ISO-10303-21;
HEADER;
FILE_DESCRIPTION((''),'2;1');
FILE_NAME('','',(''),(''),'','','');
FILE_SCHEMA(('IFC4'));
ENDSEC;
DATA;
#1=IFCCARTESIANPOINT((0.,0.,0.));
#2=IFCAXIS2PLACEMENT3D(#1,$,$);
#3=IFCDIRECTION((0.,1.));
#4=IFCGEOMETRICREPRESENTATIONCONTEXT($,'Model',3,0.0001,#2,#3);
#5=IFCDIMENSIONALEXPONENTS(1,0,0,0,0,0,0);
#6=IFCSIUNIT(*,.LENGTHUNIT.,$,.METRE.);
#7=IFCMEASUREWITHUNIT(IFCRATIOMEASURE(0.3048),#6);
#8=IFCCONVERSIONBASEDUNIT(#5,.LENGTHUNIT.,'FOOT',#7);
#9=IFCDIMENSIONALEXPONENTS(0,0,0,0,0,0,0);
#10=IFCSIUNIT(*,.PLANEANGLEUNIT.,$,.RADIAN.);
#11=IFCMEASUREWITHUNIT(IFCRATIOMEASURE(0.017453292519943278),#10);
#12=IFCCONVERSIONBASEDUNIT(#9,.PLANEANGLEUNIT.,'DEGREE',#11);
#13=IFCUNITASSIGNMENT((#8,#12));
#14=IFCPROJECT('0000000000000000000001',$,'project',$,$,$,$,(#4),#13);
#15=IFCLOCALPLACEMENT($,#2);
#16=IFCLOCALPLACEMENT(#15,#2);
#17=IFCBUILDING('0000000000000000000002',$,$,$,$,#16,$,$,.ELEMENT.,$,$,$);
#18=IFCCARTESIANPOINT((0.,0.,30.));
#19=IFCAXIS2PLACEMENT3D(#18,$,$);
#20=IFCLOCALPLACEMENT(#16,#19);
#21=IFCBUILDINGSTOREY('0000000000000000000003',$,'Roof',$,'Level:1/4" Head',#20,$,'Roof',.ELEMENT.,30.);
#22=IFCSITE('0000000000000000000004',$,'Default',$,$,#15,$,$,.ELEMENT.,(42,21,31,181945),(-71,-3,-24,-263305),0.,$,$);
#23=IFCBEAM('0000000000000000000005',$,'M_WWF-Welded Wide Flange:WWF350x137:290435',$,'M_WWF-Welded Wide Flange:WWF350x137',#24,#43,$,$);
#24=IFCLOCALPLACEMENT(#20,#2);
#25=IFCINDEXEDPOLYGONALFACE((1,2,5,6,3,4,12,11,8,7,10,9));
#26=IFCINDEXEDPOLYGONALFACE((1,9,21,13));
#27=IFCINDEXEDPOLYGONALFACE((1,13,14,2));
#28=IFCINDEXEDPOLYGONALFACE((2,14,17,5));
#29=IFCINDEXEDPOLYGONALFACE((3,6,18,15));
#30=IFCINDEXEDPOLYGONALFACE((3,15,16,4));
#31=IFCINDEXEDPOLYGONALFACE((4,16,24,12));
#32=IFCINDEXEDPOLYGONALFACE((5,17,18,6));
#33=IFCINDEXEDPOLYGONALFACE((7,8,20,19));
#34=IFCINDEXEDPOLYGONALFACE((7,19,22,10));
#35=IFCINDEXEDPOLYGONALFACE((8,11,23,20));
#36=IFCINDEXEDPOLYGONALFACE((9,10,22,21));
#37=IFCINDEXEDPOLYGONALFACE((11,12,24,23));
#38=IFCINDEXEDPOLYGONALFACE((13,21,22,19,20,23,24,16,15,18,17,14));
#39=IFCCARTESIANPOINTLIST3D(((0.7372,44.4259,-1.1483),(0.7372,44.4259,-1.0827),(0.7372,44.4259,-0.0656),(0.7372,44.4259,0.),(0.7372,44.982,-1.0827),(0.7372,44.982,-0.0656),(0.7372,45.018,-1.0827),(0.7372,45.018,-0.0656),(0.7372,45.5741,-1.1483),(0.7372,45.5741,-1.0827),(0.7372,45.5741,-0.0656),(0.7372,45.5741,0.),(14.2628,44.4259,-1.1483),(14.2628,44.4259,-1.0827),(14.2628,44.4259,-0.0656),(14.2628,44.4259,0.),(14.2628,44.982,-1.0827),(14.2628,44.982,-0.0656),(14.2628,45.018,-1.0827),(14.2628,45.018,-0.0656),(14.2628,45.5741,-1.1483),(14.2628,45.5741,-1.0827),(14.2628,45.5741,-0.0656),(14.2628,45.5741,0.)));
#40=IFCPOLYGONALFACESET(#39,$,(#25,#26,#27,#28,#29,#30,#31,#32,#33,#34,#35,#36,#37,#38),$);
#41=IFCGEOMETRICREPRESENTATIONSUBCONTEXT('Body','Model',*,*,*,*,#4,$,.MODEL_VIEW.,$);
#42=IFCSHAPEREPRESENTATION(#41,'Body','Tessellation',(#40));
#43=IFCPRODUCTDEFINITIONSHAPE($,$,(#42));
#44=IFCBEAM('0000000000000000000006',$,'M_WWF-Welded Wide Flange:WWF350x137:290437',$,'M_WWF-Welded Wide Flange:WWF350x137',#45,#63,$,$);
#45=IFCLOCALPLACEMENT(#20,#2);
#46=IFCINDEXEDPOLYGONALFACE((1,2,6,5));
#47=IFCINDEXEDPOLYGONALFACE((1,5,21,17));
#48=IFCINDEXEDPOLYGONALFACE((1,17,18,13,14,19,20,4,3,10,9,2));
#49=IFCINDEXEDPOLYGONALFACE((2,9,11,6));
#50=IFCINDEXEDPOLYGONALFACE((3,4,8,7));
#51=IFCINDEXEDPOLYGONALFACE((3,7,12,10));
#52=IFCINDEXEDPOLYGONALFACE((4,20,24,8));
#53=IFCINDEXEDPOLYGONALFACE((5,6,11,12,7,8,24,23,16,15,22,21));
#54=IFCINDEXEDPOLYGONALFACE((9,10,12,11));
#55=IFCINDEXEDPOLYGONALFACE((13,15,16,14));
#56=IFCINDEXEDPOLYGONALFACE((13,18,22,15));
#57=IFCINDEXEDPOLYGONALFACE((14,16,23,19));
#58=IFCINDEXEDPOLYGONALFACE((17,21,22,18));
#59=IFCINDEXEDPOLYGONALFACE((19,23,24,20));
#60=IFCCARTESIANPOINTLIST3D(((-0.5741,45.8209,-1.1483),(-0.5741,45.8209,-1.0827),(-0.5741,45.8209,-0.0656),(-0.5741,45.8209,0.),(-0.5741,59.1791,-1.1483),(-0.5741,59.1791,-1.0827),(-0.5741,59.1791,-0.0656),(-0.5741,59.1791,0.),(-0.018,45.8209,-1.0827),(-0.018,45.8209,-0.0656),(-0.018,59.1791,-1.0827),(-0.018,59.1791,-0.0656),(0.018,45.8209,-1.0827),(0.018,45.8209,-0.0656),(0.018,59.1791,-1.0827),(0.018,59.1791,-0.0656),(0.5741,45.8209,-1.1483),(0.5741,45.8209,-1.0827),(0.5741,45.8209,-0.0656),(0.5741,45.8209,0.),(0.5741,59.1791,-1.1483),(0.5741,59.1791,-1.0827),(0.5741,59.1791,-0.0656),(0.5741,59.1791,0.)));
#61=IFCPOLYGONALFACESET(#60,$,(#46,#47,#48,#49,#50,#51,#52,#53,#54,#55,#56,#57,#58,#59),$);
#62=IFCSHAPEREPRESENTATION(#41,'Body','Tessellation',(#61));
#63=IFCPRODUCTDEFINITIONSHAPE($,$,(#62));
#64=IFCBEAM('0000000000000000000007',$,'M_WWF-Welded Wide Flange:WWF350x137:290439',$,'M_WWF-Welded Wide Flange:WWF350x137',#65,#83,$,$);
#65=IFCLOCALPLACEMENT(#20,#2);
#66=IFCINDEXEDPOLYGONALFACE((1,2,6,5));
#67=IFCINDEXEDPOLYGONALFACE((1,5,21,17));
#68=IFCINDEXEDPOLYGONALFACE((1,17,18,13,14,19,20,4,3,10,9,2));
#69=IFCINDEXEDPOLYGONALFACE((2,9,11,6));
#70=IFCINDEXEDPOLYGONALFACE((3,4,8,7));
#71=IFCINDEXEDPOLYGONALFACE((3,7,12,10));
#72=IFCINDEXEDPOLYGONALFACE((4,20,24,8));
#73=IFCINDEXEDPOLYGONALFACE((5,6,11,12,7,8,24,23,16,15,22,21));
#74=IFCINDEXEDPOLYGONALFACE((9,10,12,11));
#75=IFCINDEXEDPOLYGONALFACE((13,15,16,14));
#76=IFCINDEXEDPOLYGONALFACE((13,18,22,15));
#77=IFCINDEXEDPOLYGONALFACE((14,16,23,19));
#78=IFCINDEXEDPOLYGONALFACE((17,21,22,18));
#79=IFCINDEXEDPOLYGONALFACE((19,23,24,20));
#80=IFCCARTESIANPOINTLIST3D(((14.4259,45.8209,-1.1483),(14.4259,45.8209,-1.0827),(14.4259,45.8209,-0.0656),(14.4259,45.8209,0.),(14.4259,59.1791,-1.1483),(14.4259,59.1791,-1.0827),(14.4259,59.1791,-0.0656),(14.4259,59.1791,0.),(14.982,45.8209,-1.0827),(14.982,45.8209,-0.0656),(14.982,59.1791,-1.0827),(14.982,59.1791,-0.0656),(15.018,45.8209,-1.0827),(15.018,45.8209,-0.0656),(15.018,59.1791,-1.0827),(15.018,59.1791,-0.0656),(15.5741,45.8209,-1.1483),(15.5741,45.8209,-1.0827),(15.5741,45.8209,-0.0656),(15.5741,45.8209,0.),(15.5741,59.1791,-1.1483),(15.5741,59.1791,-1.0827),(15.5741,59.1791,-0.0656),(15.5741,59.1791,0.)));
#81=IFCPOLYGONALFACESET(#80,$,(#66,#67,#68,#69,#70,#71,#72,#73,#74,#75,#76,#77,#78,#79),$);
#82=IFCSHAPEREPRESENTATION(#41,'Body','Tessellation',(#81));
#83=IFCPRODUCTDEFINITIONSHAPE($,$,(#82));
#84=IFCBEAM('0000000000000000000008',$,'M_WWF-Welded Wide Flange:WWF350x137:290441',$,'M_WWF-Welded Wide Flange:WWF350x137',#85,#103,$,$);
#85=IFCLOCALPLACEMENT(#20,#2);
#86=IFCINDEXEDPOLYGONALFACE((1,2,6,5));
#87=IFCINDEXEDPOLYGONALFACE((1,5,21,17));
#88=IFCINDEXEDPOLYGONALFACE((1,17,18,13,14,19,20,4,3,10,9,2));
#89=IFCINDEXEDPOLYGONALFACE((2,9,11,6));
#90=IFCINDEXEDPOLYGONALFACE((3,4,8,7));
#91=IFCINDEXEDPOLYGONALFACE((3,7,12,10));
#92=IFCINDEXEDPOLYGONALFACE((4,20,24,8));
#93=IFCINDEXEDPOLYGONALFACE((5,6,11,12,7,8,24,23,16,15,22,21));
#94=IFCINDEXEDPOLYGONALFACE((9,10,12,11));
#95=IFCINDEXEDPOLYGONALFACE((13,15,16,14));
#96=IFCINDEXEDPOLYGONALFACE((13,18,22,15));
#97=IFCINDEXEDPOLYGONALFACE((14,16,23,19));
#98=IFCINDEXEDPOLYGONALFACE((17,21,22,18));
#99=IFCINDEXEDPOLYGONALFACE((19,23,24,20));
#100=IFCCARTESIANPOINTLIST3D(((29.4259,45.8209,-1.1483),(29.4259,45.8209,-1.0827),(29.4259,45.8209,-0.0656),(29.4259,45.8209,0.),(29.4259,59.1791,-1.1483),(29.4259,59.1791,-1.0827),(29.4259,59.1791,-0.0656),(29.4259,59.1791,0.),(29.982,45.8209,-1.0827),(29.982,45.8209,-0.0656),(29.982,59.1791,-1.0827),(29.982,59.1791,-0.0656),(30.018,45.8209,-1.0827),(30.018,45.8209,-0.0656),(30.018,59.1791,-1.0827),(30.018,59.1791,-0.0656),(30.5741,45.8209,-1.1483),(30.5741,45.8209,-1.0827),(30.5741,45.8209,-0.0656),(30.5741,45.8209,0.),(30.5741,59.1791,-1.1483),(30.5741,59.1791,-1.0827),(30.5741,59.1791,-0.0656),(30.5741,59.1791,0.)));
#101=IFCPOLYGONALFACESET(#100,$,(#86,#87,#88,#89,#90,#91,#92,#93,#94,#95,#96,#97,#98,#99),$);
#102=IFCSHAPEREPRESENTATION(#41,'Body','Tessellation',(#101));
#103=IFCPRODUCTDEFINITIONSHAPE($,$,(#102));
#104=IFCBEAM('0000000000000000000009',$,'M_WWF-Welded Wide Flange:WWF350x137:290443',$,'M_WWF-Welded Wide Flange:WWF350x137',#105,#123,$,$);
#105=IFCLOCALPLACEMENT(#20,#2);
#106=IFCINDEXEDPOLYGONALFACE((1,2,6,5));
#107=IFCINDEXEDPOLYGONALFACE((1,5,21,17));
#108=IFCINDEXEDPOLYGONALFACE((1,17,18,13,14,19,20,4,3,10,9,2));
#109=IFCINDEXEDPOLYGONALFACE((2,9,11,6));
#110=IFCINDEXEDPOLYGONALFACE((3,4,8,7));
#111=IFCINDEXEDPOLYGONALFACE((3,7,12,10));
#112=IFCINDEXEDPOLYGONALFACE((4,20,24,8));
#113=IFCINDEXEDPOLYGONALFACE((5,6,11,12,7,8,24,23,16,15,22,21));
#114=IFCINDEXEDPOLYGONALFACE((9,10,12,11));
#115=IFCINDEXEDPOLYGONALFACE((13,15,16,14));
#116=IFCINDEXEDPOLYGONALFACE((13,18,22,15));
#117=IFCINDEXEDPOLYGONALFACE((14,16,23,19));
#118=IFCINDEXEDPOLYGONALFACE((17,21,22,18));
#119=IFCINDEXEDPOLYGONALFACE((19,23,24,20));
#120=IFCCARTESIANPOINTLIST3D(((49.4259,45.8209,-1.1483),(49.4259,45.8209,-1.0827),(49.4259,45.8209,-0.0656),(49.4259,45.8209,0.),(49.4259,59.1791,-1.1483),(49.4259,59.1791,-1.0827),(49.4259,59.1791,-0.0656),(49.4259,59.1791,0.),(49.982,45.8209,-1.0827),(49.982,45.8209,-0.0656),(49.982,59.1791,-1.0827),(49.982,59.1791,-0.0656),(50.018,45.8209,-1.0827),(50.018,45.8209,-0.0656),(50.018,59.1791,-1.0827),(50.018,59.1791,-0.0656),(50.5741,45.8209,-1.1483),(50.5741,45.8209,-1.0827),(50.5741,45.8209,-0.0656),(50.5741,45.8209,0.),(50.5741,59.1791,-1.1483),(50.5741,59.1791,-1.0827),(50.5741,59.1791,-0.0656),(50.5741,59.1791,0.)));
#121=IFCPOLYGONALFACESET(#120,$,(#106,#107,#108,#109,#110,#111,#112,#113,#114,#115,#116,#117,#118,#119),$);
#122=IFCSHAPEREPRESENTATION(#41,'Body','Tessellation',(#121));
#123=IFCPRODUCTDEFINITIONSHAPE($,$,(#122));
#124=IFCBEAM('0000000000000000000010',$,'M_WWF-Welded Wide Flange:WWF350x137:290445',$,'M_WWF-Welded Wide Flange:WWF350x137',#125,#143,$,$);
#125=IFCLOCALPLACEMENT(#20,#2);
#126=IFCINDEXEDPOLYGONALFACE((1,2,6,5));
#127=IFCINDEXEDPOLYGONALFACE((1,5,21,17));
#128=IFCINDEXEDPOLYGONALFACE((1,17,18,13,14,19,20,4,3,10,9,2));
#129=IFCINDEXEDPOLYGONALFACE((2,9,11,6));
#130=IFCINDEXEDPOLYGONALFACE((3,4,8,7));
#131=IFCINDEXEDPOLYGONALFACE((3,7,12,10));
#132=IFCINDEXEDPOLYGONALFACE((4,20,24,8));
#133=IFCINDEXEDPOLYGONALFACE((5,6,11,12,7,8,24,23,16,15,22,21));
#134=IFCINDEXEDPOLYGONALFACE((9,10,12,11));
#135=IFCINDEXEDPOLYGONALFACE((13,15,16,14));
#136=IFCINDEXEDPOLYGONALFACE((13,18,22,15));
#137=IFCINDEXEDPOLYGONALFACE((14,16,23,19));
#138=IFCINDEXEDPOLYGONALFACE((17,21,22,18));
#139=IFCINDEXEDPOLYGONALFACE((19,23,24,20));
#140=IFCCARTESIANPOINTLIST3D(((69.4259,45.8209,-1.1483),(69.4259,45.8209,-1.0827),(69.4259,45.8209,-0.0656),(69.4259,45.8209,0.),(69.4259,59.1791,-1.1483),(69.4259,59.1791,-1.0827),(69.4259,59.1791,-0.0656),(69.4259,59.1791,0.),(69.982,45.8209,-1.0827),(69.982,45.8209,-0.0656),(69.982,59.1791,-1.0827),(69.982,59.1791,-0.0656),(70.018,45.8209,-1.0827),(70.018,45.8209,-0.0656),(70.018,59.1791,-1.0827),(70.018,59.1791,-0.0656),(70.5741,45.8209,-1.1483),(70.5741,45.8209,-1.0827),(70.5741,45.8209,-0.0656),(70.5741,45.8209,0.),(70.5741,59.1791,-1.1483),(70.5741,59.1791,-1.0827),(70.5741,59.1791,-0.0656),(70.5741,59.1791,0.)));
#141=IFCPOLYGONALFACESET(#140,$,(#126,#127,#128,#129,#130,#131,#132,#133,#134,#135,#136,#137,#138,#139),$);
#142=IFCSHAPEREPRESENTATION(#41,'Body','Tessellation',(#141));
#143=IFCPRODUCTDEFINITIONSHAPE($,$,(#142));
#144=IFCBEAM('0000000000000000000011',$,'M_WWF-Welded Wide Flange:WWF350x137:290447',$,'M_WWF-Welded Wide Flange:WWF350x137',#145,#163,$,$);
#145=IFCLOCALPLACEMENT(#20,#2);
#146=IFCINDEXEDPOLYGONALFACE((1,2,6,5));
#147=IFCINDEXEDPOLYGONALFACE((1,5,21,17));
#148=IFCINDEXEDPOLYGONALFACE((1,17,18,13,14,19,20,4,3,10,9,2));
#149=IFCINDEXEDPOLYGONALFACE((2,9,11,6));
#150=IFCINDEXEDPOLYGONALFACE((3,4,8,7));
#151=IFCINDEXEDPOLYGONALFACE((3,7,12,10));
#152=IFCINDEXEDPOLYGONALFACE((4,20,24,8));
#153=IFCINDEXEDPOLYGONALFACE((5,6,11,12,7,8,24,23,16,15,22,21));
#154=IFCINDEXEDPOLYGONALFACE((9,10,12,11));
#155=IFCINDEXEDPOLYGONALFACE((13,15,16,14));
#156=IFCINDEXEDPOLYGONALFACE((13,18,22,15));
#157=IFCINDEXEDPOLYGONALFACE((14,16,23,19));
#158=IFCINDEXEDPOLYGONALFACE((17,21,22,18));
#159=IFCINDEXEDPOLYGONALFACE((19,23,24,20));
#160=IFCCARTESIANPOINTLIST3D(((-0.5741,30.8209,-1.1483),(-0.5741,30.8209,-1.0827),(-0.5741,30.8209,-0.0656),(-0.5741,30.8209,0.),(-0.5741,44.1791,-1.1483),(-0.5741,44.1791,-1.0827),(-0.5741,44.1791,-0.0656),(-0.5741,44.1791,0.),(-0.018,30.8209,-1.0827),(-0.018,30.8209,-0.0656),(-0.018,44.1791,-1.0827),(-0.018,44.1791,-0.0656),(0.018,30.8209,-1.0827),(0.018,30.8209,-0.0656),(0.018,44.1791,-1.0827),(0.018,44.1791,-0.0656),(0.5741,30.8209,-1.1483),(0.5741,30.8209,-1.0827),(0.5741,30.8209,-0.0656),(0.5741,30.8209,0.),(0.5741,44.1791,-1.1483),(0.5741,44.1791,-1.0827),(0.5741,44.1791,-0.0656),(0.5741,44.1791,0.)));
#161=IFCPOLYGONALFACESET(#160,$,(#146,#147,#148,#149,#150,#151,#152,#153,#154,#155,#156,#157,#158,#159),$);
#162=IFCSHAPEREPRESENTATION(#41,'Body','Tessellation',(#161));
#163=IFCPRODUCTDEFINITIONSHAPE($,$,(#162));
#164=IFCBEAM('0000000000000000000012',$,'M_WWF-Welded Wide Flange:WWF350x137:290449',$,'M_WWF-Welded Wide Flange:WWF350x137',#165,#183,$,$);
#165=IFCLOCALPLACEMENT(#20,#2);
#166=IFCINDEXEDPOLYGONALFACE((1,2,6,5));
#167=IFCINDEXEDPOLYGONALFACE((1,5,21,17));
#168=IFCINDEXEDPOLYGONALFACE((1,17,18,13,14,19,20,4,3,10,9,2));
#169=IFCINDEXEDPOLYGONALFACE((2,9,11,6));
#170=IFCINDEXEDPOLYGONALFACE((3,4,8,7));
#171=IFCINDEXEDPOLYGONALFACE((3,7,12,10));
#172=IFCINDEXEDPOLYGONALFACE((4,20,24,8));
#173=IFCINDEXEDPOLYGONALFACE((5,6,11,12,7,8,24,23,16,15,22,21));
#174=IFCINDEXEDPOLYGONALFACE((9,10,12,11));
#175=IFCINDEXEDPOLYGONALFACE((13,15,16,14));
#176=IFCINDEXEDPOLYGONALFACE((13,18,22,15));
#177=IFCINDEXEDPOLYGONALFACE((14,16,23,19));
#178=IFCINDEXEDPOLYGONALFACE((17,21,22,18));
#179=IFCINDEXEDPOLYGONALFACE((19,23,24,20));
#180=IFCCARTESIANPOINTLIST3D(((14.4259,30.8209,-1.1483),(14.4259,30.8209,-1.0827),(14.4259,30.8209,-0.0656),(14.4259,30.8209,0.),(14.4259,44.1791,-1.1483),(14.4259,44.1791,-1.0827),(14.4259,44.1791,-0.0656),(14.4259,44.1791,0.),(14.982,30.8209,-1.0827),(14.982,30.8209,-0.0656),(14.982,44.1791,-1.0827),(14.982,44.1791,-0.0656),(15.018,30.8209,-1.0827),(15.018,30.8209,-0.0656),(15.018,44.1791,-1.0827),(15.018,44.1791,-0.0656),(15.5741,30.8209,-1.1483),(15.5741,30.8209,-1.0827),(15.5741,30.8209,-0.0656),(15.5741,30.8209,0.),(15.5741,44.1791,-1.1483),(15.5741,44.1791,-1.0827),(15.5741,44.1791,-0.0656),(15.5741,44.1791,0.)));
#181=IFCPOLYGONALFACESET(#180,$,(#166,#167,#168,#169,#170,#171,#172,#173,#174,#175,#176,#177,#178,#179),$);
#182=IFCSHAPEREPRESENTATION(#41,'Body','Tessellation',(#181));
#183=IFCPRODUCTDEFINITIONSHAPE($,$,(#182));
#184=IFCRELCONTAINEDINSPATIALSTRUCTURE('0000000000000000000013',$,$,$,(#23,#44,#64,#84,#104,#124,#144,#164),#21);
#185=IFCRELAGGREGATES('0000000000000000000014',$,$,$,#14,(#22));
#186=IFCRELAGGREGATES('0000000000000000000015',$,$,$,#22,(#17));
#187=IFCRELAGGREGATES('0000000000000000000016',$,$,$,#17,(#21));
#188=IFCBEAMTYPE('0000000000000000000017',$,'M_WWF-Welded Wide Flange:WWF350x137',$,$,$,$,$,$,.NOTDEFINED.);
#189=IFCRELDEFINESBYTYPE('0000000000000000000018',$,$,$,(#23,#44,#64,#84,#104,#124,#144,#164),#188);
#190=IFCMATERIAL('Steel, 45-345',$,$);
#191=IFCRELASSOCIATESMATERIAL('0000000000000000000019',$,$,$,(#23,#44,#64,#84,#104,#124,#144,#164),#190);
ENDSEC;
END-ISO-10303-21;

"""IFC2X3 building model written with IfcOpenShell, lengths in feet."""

from ifc_helpers import new_model, entity, si_unit, converted_unit, direction, frame, frame_2d, origin, place, context, subcontext, project, spatial, i_section, extrude, material, type_object, element, save


model = new_model("IFC2X3")

# Units and contexts
model_context = context("Model", 3, precision=0.0001, world=origin(), true_north=direction((0.0, 1.0)))
body_context = subcontext(model_context, "Body", "Model", "MODEL_VIEW")
ifc_project = project(units=[converted_unit("LENGTHUNIT", "FOOT", entity("IfcRatioMeasure", 0.3048), si_unit("LENGTHUNIT", "METRE"), dimensions=[1, 0, 0, 0, 0, 0, 0]), converted_unit("PLANEANGLEUNIT", "DEGREE", entity("IfcRatioMeasure", 0.017453292519943278), si_unit("PLANEANGLEUNIT", "RADIAN"), dimensions=[0, 0, 0, 0, 0, 0, 0])], contexts=[model_context])

# Site, building, storey
site_placement = place(None, origin())
site = spatial("IfcSite", under=ifc_project, at=site_placement, Name="Default", CompositionType="ELEMENT", RefLatitude=(42, 21, 31, 181945), RefLongitude=(-71, -3, -24, -263305), RefElevation=0.0)
building_placement = place(site_placement, origin())
building = spatial("IfcBuilding", under=site, at=building_placement, CompositionType="ELEMENT")
storey_placement = place(building_placement, frame((0.0, 0.0, 30.0)))
storey = spatial("IfcBuildingStorey", under=building, at=storey_placement, Name="Roof", ObjectType="Level:1/4\" Head", LongName="Roof", CompositionType="ELEMENT", Elevation=30.0)

# Beams
ifc_material = material(Name="Steel, 45-345")
beam_type = type_object("IfcBeamType", Name="M_WWF-Welded Wide Flange:WWF350x137", PredefinedType="NOTDEFINED")
beam_1_placement = place(storey_placement, frame((0.0, 45.0, 0.0)))
element("IfcBeam", 1, at=beam_1_placement, inside=storey, type_object=beam_type, material=ifc_material, Name="M_WWF-Welded Wide Flange:WWF350x137:290435", ObjectType="M_WWF-Welded Wide Flange:WWF350x137", context=body_context, shape_type="SweptSolid", body=[
    extrude(i_section(OverallWidth=1.1483, OverallDepth=1.1483, WebThickness=0.0361, FlangeThickness=0.0656, at=frame_2d((0.0, 0.0), x_axis=(0.0, 1.0))), frame((0.7372, 0.0, -0.5741), z_axis=(1.0, 0.0, 0.0), x_axis=(0.0, 0.0, -1.0)), (0.0, 0.0, 1.0), 13.5256),
])
beam_2_placement = place(storey_placement, frame((0.0, 45.0, 0.0), z_axis=(0.0, 0.0, 1.0), x_axis=(0.0, 1.0, 0.0)))
element("IfcBeam", 2, at=beam_2_placement, inside=storey, type_object=beam_type, material=ifc_material, Name="M_WWF-Welded Wide Flange:WWF350x137:290437", ObjectType="M_WWF-Welded Wide Flange:WWF350x137", context=body_context, shape_type="SweptSolid", body=[
    extrude(i_section(OverallWidth=1.1483, OverallDepth=1.1483, WebThickness=0.0361, FlangeThickness=0.0656, at=frame_2d((0.0, 0.0), x_axis=(0.0, 1.0))), frame((0.8209, 0.0, -0.5741), z_axis=(1.0, 0.0, 0.0), x_axis=(0.0, 0.0, -1.0)), (0.0, 0.0, 1.0), 13.3583),
])
beam_3_placement = place(storey_placement, frame((15.0, 45.0, 0.0), z_axis=(0.0, 0.0, 1.0), x_axis=(0.0, 1.0, 0.0)))
element("IfcBeam", 3, at=beam_3_placement, inside=storey, type_object=beam_type, material=ifc_material, Name="M_WWF-Welded Wide Flange:WWF350x137:290439", ObjectType="M_WWF-Welded Wide Flange:WWF350x137", context=body_context, shape_type="SweptSolid", body=[
    extrude(i_section(OverallWidth=1.1483, OverallDepth=1.1483, WebThickness=0.0361, FlangeThickness=0.0656, at=frame_2d((0.0, 0.0), x_axis=(0.0, 1.0))), frame((0.8209, 0.0, -0.5741), z_axis=(1.0, 0.0, 0.0), x_axis=(0.0, 0.0, -1.0)), (0.0, 0.0, 1.0), 13.3583),
])
beam_4_placement = place(storey_placement, frame((30.0, 45.0, 0.0), z_axis=(0.0, 0.0, 1.0), x_axis=(0.0, 1.0, 0.0)))
element("IfcBeam", 4, at=beam_4_placement, inside=storey, type_object=beam_type, material=ifc_material, Name="M_WWF-Welded Wide Flange:WWF350x137:290441", ObjectType="M_WWF-Welded Wide Flange:WWF350x137", context=body_context, shape_type="SweptSolid", body=[
    extrude(i_section(OverallWidth=1.1483, OverallDepth=1.1483, WebThickness=0.0361, FlangeThickness=0.0656, at=frame_2d((0.0, 0.0), x_axis=(0.0, 1.0))), frame((0.8209, 0.0, -0.5741), z_axis=(1.0, 0.0, 0.0), x_axis=(0.0, 0.0, -1.0)), (0.0, 0.0, 1.0), 13.3583),
])
beam_5_placement = place(storey_placement, frame((50.0, 45.0, 0.0), z_axis=(0.0, 0.0, 1.0), x_axis=(0.0, 1.0, 0.0)))
element("IfcBeam", 5, at=beam_5_placement, inside=storey, type_object=beam_type, material=ifc_material, Name="M_WWF-Welded Wide Flange:WWF350x137:290443", ObjectType="M_WWF-Welded Wide Flange:WWF350x137", context=body_context, shape_type="SweptSolid", body=[
    extrude(i_section(OverallWidth=1.1483, OverallDepth=1.1483, WebThickness=0.0361, FlangeThickness=0.0656, at=frame_2d((0.0, 0.0), x_axis=(0.0, 1.0))), frame((0.8209, 0.0, -0.5741), z_axis=(1.0, 0.0, 0.0), x_axis=(0.0, 0.0, -1.0)), (0.0, 0.0, 1.0), 13.3583),
])
beam_6_placement = place(storey_placement, frame((70.0, 45.0, 0.0), z_axis=(0.0, 0.0, 1.0), x_axis=(0.0, 1.0, 0.0)))
element("IfcBeam", 6, at=beam_6_placement, inside=storey, type_object=beam_type, material=ifc_material, Name="M_WWF-Welded Wide Flange:WWF350x137:290445", ObjectType="M_WWF-Welded Wide Flange:WWF350x137", context=body_context, shape_type="SweptSolid", body=[
    extrude(i_section(OverallWidth=1.1483, OverallDepth=1.1483, WebThickness=0.0361, FlangeThickness=0.0656, at=frame_2d((0.0, 0.0), x_axis=(0.0, 1.0))), frame((0.8209, 0.0, -0.5741), z_axis=(1.0, 0.0, 0.0), x_axis=(0.0, 0.0, -1.0)), (0.0, 0.0, 1.0), 13.3583),
])
beam_7_placement = place(storey_placement, frame((0.0, 30.0, 0.0), z_axis=(0.0, 0.0, 1.0), x_axis=(0.0, 1.0, 0.0)))
element("IfcBeam", 7, at=beam_7_placement, inside=storey, type_object=beam_type, material=ifc_material, Name="M_WWF-Welded Wide Flange:WWF350x137:290447", ObjectType="M_WWF-Welded Wide Flange:WWF350x137", context=body_context, shape_type="SweptSolid", body=[
    extrude(i_section(OverallWidth=1.1483, OverallDepth=1.1483, WebThickness=0.0361, FlangeThickness=0.0656, at=frame_2d((0.0, 0.0), x_axis=(0.0, 1.0))), frame((0.8209, 0.0, -0.5741), z_axis=(1.0, 0.0, 0.0), x_axis=(0.0, 0.0, -1.0)), (0.0, 0.0, 1.0), 13.3583),
])
beam_8_placement = place(storey_placement, frame((15.0, 30.0, 0.0), z_axis=(0.0, 0.0, 1.0), x_axis=(0.0, 1.0, 0.0)))
element("IfcBeam", 8, at=beam_8_placement, inside=storey, type_object=beam_type, material=ifc_material, Name="M_WWF-Welded Wide Flange:WWF350x137:290449", ObjectType="M_WWF-Welded Wide Flange:WWF350x137", context=body_context, shape_type="SweptSolid", body=[
    extrude(i_section(OverallWidth=1.1483, OverallDepth=1.1483, WebThickness=0.0361, FlangeThickness=0.0656, at=frame_2d((0.0, 0.0), x_axis=(0.0, 1.0))), frame((0.8209, 0.0, -0.5741), z_axis=(1.0, 0.0, 0.0), x_axis=(0.0, 0.0, -1.0)), (0.0, 0.0, 1.0), 13.3583),
])

save(model, "model.ifc")
